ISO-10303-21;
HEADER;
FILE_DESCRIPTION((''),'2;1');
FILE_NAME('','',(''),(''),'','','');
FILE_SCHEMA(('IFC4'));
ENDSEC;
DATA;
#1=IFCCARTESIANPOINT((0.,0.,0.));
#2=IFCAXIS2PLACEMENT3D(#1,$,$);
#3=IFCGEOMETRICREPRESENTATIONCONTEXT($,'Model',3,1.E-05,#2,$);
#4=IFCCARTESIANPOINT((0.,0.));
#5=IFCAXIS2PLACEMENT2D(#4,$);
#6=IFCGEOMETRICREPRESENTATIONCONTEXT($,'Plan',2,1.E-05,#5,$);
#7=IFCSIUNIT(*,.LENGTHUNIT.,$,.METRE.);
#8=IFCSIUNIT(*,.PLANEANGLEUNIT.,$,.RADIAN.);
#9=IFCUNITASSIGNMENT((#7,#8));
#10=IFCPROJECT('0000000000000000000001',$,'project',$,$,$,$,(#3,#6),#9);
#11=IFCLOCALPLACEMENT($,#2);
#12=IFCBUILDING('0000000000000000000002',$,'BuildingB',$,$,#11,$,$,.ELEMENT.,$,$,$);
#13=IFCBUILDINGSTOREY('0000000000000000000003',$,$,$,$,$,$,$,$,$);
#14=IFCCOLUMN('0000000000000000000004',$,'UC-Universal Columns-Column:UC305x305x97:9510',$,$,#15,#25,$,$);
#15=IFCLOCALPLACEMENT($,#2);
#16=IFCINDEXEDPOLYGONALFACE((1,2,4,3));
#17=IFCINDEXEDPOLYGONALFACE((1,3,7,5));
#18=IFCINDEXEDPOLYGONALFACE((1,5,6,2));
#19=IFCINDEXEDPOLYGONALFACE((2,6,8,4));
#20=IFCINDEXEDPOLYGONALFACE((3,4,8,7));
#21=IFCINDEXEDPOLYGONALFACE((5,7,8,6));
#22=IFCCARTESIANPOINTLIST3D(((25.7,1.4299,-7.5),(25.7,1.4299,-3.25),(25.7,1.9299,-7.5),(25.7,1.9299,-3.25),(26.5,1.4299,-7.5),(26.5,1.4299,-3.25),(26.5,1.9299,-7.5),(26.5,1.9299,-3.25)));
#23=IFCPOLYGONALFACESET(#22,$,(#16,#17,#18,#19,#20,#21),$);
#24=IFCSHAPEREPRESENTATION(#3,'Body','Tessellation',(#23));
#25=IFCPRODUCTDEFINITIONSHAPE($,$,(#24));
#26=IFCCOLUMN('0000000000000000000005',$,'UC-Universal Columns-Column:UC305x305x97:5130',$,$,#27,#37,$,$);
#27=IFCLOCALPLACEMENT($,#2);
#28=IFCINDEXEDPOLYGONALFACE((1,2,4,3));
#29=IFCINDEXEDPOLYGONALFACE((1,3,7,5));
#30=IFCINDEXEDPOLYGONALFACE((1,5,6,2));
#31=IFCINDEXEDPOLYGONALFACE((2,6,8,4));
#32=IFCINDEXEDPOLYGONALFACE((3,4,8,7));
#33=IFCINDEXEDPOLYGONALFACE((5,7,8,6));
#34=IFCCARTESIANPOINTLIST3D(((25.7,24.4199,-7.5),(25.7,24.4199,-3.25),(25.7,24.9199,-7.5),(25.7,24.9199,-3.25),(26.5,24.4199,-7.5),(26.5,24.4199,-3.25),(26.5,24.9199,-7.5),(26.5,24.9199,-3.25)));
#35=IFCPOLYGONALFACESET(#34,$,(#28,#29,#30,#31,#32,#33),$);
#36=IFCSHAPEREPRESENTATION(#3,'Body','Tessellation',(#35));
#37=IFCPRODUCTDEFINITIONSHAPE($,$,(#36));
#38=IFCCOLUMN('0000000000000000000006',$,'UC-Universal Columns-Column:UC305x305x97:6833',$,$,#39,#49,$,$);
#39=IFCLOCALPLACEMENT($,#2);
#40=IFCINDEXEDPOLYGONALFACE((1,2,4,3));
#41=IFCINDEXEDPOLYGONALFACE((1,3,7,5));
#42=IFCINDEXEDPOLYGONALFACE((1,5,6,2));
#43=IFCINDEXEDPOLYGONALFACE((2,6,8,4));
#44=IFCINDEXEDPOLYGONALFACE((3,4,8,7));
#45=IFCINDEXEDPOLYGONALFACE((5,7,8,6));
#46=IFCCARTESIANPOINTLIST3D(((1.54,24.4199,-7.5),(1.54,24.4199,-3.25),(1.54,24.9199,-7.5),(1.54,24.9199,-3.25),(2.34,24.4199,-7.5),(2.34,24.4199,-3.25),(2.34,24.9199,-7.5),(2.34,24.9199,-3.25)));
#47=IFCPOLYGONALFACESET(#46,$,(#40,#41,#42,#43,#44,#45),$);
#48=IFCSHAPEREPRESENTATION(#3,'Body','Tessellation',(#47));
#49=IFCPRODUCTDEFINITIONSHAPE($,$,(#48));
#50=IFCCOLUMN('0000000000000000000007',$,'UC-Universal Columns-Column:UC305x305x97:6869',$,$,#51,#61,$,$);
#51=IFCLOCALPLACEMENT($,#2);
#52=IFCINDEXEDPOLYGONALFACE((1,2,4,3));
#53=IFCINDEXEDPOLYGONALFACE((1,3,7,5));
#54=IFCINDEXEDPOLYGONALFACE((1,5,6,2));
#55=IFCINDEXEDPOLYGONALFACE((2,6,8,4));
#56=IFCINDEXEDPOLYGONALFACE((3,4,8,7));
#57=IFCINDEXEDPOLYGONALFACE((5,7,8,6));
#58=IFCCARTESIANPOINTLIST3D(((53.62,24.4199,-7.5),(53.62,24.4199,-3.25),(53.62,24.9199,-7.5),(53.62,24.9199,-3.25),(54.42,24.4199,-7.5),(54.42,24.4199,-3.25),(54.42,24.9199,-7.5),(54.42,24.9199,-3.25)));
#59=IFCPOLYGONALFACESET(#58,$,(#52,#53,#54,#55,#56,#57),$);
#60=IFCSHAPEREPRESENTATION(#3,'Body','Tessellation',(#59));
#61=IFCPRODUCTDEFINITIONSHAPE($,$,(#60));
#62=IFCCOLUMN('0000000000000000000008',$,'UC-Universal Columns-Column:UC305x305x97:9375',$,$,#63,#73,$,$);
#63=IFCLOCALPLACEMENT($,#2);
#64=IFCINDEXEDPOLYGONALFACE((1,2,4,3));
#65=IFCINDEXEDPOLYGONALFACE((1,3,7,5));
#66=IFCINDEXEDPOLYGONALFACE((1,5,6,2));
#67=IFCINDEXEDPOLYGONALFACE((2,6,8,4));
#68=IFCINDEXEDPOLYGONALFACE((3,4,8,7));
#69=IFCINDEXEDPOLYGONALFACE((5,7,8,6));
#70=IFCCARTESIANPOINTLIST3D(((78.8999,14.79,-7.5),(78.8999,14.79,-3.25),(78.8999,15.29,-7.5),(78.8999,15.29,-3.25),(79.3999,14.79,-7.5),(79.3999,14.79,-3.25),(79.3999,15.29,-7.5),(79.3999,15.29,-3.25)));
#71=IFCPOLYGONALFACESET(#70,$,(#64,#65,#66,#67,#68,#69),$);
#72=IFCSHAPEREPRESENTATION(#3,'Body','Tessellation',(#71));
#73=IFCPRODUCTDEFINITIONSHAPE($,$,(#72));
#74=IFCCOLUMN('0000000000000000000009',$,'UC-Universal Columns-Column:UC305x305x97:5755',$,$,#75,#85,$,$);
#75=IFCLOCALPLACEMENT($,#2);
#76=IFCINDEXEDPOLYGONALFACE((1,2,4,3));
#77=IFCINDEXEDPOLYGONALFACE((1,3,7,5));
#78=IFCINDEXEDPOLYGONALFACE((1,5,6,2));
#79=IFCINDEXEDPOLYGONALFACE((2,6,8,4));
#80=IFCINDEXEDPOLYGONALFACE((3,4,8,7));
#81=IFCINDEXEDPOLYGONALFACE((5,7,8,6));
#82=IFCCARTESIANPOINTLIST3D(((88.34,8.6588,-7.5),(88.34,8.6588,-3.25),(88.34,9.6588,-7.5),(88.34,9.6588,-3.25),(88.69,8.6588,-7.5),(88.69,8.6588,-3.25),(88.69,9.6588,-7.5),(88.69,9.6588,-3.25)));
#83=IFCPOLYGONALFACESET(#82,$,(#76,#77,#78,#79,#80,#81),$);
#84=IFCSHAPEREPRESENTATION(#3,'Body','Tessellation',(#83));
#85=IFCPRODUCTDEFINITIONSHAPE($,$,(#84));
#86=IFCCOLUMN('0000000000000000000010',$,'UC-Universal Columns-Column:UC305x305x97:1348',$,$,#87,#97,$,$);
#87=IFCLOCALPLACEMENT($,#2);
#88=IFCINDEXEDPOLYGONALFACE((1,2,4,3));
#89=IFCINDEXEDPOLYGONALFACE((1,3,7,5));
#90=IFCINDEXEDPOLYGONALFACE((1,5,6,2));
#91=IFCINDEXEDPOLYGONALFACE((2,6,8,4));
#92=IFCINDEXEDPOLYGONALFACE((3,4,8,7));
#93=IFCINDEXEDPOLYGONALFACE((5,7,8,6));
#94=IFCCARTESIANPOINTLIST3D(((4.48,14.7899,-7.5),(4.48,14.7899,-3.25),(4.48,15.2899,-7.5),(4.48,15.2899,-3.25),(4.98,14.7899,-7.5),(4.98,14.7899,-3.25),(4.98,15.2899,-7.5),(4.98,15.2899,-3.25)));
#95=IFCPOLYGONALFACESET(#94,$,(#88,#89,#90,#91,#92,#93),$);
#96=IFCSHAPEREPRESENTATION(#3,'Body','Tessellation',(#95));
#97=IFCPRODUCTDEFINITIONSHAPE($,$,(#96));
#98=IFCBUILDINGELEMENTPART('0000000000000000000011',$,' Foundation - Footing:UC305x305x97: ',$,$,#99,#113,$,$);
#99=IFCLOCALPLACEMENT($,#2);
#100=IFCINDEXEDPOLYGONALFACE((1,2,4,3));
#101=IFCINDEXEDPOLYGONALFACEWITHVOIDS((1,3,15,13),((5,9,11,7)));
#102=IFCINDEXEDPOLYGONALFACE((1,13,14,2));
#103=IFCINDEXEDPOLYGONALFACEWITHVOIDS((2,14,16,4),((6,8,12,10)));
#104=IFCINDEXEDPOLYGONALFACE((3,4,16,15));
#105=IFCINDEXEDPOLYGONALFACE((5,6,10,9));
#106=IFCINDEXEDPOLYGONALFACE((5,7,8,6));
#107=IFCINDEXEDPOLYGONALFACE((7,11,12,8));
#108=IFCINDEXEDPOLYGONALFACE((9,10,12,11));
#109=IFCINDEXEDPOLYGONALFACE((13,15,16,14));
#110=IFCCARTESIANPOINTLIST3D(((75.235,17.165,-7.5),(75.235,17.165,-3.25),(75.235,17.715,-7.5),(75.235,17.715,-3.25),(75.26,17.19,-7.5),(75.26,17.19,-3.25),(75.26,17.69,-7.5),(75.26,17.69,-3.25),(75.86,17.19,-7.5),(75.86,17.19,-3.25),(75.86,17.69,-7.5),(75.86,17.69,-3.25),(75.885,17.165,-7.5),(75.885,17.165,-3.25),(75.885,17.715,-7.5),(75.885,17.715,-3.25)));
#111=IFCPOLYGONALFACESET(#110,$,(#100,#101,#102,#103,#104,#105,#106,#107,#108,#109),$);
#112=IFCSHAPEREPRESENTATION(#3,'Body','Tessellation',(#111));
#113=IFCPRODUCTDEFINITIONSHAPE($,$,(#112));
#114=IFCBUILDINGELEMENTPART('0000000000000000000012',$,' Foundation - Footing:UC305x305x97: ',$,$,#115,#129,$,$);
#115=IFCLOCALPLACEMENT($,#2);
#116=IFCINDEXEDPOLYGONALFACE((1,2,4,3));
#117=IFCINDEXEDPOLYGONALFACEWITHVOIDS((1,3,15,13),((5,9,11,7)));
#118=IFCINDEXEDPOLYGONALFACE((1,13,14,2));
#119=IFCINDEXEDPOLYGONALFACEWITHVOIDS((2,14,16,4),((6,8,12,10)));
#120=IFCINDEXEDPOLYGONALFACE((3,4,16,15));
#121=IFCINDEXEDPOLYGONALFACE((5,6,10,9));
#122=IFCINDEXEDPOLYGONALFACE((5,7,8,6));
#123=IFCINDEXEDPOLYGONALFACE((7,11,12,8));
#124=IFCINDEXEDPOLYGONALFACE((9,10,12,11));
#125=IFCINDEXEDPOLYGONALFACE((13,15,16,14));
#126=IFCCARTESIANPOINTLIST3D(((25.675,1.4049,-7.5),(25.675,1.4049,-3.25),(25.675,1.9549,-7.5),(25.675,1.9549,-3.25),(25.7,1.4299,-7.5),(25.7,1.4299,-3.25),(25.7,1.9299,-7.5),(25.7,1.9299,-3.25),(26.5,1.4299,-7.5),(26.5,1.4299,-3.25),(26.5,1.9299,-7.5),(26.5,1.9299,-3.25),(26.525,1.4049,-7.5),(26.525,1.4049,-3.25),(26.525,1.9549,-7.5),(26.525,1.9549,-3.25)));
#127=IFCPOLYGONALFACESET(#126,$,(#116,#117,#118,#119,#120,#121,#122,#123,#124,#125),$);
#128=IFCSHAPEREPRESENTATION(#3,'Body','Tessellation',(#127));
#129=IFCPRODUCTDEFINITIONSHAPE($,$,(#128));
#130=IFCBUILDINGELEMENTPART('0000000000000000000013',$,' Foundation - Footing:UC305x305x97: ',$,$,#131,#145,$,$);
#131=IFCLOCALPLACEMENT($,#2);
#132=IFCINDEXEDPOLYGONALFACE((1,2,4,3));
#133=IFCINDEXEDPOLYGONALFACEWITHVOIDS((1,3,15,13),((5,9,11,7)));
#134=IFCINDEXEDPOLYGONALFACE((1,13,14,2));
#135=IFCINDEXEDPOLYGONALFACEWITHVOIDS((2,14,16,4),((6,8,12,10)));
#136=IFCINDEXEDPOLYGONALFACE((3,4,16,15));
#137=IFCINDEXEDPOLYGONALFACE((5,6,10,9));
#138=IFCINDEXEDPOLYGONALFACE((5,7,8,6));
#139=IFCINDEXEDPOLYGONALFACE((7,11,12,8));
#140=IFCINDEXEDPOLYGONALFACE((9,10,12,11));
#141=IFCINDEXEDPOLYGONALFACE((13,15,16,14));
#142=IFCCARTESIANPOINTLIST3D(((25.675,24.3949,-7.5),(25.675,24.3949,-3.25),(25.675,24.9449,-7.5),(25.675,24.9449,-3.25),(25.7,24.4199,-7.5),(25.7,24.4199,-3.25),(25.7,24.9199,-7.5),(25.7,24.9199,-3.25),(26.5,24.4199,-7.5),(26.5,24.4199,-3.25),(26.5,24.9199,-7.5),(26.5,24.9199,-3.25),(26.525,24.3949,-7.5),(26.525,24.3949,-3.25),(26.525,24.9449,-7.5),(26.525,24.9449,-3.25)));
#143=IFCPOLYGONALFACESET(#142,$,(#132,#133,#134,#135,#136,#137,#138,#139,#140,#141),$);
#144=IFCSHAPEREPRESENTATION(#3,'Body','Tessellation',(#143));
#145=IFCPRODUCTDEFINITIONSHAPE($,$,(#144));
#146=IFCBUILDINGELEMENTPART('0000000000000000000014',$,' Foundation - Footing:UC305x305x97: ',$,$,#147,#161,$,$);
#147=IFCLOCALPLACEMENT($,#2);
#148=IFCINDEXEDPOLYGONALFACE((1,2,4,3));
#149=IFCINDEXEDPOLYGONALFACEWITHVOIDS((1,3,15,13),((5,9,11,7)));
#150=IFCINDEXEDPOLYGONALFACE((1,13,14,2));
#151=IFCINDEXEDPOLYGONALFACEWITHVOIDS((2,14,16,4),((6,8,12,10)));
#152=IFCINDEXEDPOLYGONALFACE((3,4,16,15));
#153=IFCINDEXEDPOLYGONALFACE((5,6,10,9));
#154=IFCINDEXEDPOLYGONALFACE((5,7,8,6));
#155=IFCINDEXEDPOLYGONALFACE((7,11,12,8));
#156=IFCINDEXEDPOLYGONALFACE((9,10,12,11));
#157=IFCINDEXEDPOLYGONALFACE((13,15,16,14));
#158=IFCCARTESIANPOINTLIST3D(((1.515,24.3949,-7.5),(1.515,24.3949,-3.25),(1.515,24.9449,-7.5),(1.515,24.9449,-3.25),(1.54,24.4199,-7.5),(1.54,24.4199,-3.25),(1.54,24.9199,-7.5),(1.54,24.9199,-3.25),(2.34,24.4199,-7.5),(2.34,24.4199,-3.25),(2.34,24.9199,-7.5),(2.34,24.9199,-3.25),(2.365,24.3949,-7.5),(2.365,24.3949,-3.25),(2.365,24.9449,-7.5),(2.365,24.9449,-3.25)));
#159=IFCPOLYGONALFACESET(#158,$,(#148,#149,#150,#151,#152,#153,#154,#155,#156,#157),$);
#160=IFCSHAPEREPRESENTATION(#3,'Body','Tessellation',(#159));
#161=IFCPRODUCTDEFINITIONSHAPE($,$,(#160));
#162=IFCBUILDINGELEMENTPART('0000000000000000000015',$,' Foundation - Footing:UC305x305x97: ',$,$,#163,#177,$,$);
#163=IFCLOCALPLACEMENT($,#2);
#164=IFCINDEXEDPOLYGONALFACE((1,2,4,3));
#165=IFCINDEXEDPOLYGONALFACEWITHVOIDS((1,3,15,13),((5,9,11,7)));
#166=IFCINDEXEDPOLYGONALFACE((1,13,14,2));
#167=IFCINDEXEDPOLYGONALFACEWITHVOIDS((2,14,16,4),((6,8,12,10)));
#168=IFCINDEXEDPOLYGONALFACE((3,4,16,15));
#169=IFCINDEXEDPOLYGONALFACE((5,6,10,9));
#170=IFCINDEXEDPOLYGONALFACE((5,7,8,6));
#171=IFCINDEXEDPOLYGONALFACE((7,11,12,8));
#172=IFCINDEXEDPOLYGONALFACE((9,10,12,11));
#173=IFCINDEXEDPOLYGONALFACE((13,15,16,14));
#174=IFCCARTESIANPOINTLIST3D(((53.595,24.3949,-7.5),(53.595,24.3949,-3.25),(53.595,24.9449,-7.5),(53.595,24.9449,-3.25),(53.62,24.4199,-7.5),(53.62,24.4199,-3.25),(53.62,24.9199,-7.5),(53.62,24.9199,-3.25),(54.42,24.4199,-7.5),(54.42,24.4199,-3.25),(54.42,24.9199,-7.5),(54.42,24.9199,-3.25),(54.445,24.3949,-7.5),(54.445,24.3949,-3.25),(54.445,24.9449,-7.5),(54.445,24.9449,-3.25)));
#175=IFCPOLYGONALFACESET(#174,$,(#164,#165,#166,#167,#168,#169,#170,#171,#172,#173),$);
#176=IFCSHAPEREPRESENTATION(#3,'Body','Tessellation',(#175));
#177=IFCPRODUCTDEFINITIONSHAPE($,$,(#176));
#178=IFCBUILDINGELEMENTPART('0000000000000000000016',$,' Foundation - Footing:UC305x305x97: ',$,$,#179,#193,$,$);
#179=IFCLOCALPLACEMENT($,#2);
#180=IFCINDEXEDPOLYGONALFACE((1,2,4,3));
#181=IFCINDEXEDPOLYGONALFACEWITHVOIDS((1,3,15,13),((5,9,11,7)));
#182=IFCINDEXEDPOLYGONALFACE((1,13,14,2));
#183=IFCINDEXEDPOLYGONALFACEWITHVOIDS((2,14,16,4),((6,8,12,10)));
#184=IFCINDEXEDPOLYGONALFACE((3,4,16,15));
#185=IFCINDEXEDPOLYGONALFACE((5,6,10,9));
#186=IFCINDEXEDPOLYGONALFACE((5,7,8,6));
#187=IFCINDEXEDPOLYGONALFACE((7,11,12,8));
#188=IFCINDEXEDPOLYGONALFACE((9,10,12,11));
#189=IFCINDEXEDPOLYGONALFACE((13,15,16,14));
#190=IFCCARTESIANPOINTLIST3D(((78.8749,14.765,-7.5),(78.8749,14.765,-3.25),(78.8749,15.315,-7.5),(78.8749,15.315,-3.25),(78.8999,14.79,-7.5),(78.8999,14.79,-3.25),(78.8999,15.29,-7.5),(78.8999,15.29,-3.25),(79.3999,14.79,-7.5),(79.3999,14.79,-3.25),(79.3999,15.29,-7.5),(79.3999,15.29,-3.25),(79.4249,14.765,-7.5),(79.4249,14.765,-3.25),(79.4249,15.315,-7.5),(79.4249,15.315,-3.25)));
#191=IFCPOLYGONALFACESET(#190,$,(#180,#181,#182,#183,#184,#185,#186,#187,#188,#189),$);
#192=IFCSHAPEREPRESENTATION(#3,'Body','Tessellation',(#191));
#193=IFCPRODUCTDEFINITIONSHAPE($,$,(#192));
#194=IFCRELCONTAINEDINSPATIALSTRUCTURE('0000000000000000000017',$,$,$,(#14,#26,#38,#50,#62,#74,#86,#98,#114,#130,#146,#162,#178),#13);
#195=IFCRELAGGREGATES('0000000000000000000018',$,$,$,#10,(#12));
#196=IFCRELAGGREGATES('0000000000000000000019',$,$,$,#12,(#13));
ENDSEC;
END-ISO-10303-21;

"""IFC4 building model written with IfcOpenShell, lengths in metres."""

from ifc_helpers import new_model, si_unit, origin, origin_2d, place, context, project, spatial, polyline, outline, extrude, element, save


model = new_model("IFC4")

# Units and contexts
model_context = context("Model", 3, precision=1e-05, world=origin())
plan_context = context("Plan", 2, precision=1e-05, world=origin_2d())
ifc_project = project(units=[si_unit("LENGTHUNIT", "METRE"), si_unit("PLANEANGLEUNIT", "RADIAN")], contexts=[model_context, plan_context])

# Building, storey
building_placement = place(None, origin())
building = spatial("IfcBuilding", under=ifc_project, at=building_placement, Name="BuildingB", CompositionType="ELEMENT")
storey = spatial("IfcBuildingStorey", under=building)

# Columns
element("IfcColumn", 1, inside=storey, Name="UC-Universal Columns-Column:UC305x305x97:9510", context=model_context, shape_type="SweptSolid", body=[
    extrude(outline(polyline([(25.7, 1.4299, -7.5), (26.5, 1.4299, -7.5), (26.5, 1.9299, -7.5), (25.7, 1.9299, -7.5), (25.7, 1.4299, -7.5)])), None, (0.0, 0.0, 1.0), 4.25),
])
element("IfcColumn", 2, inside=storey, Name="UC-Universal Columns-Column:UC305x305x97:5130", context=model_context, shape_type="SweptSolid", body=[
    extrude(outline(polyline([(25.7, 24.4199, -7.5), (26.5, 24.4199, -7.5), (26.5, 24.9199, -7.5), (25.7, 24.9199, -7.5), (25.7, 24.4199, -7.5)])), None, (0.0, 0.0, 1.0), 4.25),
])
element("IfcColumn", 3, inside=storey, Name="UC-Universal Columns-Column:UC305x305x97:6833", context=model_context, shape_type="SweptSolid", body=[
    extrude(outline(polyline([(1.54, 24.4199, -7.5), (2.34, 24.4199, -7.5), (2.34, 24.9199, -7.5), (1.54, 24.9199, -7.5), (1.54, 24.4199, -7.5)])), None, (0.0, 0.0, 1.0), 4.25),
])
element("IfcColumn", 4, inside=storey, Name="UC-Universal Columns-Column:UC305x305x97:6869", context=model_context, shape_type="SweptSolid", body=[
    extrude(outline(polyline([(54.42, 24.4199, -7.5), (53.62, 24.4199, -7.5), (53.62, 24.9199, -7.5), (54.42, 24.9199, -7.5), (54.42, 24.4199, -7.5)])), None, (0.0, 0.0, 1.0), 4.25),
])
element("IfcColumn", 5, inside=storey, Name="UC-Universal Columns-Column:UC305x305x97:9375", context=model_context, shape_type="SweptSolid", body=[
    extrude(outline(polyline([(78.8999, 15.29, -7.5), (79.3999, 15.29, -7.5), (79.3999, 14.79, -7.5), (78.8999, 14.79, -7.5), (78.8999, 15.29, -7.5)])), None, (0.0, 0.0, 1.0), 4.25),
])
element("IfcColumn", 6, inside=storey, Name="UC-Universal Columns-Column:UC305x305x97:5755", context=model_context, shape_type="SweptSolid", body=[
    extrude(outline(polyline([(88.34, 8.6588, -7.5), (88.69, 8.6588, -7.5), (88.69, 9.6588, -7.5), (88.34, 9.6588, -7.5), (88.34, 8.6588, -7.5)])), None, (0.0, 0.0, 1.0), 4.25),
])
element("IfcColumn", 7, inside=storey, Name="UC-Universal Columns-Column:UC305x305x97:1348", context=model_context, shape_type="SweptSolid", body=[
    extrude(outline(polyline([(4.98, 15.2899, -7.5), (4.48, 15.2899, -7.5), (4.48, 14.7899, -7.5), (4.98, 14.7899, -7.5), (4.98, 15.2899, -7.5)])), None, (0.0, 0.0, 1.0), 4.25),
])

# Building element parts, openings
building_element_part_1 = element("IfcBuildingElementPart", 8, inside=storey, Name=" Foundation - Footing:UC305x305x97: ", context=model_context, shape_type="SweptSolid", body=[
    extrude(outline(polyline([(75.235, 17.715, -7.5), (75.885, 17.715, -7.5), (75.885, 17.165, -7.5), (75.235, 17.165, -7.5), (75.235, 17.715, -7.5)])), None, (0.0, 0.0, 1.0), 4.25),
])
element("IfcOpeningElement", 9, inside=storey, cuts=building_element_part_1, context=model_context, shape_type="SweptSolid", body=[
    extrude(outline(polyline([(75.26, 17.69, -7.5), (75.86, 17.69, -7.5), (75.86, 17.19, -7.5), (75.26, 17.19, -7.5), (75.26, 17.69, -7.5)])), None, (0.0, 0.0, 1.0), 4.25),
])
building_element_part_2 = element("IfcBuildingElementPart", 10, inside=storey, Name=" Foundation - Footing:UC305x305x97: ", context=model_context, shape_type="SweptSolid", body=[
    extrude(outline(polyline([(25.675, 1.4049, -7.5), (26.525, 1.4049, -7.5), (26.525, 1.9549, -7.5), (25.675, 1.9549, -7.5), (25.675, 1.4049, -7.5)])), None, (0.0, 0.0, 1.0), 4.25),
])
element("IfcOpeningElement", 11, inside=storey, cuts=building_element_part_2, context=model_context, shape_type="SweptSolid", body=[
    extrude(outline(polyline([(25.7, 1.4299, -7.5), (26.5, 1.4299, -7.5), (26.5, 1.9299, -7.5), (25.7, 1.9299, -7.5), (25.7, 1.4299, -7.5)])), None, (0.0, 0.0, 1.0), 4.25),
])
building_element_part_3 = element("IfcBuildingElementPart", 12, inside=storey, Name=" Foundation - Footing:UC305x305x97: ", context=model_context, shape_type="SweptSolid", body=[
    extrude(outline(polyline([(25.675, 24.3949, -7.5), (26.525, 24.3949, -7.5), (26.525, 24.9449, -7.5), (25.675, 24.9449, -7.5), (25.675, 24.3949, -7.5)])), None, (0.0, 0.0, 1.0), 4.25),
])
element("IfcOpeningElement", 13, inside=storey, cuts=building_element_part_3, context=model_context, shape_type="SweptSolid", body=[
    extrude(outline(polyline([(25.7, 24.4199, -7.5), (26.5, 24.4199, -7.5), (26.5, 24.9199, -7.5), (25.7, 24.9199, -7.5), (25.7, 24.4199, -7.5)])), None, (0.0, 0.0, 1.0), 4.25),
])
building_element_part_4 = element("IfcBuildingElementPart", 14, inside=storey, Name=" Foundation - Footing:UC305x305x97: ", context=model_context, shape_type="SweptSolid", body=[
    extrude(outline(polyline([(1.515, 24.3949, -7.5), (2.365, 24.3949, -7.5), (2.365, 24.9449, -7.5), (1.515, 24.9449, -7.5), (1.515, 24.3949, -7.5)])), None, (0.0, 0.0, 1.0), 4.25),
])
element("IfcOpeningElement", 15, inside=storey, cuts=building_element_part_4, context=model_context, shape_type="SweptSolid", body=[
    extrude(outline(polyline([(1.54, 24.4199, -7.5), (2.34, 24.4199, -7.5), (2.34, 24.9199, -7.5), (1.54, 24.9199, -7.5), (1.54, 24.4199, -7.5)])), None, (0.0, 0.0, 1.0), 4.25),
])
building_element_part_5 = element("IfcBuildingElementPart", 16, inside=storey, Name=" Foundation - Footing:UC305x305x97: ", context=model_context, shape_type="SweptSolid", body=[
    extrude(outline(polyline([(54.445, 24.3949, -7.5), (53.595, 24.3949, -7.5), (53.595, 24.9449, -7.5), (54.445, 24.9449, -7.5), (54.445, 24.3949, -7.5)])), None, (0.0, 0.0, 1.0), 4.25),
])
element("IfcOpeningElement", 17, inside=storey, cuts=building_element_part_5, context=model_context, shape_type="SweptSolid", body=[
    extrude(outline(polyline([(54.42, 24.4199, -7.5), (53.62, 24.4199, -7.5), (53.62, 24.9199, -7.5), (54.42, 24.9199, -7.5), (54.42, 24.4199, -7.5)])), None, (0.0, 0.0, 1.0), 4.25),
])
building_element_part_6 = element("IfcBuildingElementPart", 18, inside=storey, Name=" Foundation - Footing:UC305x305x97: ", context=model_context, shape_type="SweptSolid", body=[
    extrude(outline(polyline([(78.8749, 15.315, -7.5), (79.4249, 15.315, -7.5), (79.4249, 14.765, -7.5), (78.8749, 14.765, -7.5), (78.8749, 15.315, -7.5)])), None, (0.0, 0.0, 1.0), 4.25),
])
element("IfcOpeningElement", 19, inside=storey, cuts=building_element_part_6, context=model_context, shape_type="SweptSolid", body=[
    extrude(outline(polyline([(78.8999, 15.29, -7.5), (79.3999, 15.29, -7.5), (79.3999, 14.79, -7.5), (78.8999, 14.79, -7.5), (78.8999, 15.29, -7.5)])), None, (0.0, 0.0, 1.0), 4.25),
])

save(model, "model.ifc")
